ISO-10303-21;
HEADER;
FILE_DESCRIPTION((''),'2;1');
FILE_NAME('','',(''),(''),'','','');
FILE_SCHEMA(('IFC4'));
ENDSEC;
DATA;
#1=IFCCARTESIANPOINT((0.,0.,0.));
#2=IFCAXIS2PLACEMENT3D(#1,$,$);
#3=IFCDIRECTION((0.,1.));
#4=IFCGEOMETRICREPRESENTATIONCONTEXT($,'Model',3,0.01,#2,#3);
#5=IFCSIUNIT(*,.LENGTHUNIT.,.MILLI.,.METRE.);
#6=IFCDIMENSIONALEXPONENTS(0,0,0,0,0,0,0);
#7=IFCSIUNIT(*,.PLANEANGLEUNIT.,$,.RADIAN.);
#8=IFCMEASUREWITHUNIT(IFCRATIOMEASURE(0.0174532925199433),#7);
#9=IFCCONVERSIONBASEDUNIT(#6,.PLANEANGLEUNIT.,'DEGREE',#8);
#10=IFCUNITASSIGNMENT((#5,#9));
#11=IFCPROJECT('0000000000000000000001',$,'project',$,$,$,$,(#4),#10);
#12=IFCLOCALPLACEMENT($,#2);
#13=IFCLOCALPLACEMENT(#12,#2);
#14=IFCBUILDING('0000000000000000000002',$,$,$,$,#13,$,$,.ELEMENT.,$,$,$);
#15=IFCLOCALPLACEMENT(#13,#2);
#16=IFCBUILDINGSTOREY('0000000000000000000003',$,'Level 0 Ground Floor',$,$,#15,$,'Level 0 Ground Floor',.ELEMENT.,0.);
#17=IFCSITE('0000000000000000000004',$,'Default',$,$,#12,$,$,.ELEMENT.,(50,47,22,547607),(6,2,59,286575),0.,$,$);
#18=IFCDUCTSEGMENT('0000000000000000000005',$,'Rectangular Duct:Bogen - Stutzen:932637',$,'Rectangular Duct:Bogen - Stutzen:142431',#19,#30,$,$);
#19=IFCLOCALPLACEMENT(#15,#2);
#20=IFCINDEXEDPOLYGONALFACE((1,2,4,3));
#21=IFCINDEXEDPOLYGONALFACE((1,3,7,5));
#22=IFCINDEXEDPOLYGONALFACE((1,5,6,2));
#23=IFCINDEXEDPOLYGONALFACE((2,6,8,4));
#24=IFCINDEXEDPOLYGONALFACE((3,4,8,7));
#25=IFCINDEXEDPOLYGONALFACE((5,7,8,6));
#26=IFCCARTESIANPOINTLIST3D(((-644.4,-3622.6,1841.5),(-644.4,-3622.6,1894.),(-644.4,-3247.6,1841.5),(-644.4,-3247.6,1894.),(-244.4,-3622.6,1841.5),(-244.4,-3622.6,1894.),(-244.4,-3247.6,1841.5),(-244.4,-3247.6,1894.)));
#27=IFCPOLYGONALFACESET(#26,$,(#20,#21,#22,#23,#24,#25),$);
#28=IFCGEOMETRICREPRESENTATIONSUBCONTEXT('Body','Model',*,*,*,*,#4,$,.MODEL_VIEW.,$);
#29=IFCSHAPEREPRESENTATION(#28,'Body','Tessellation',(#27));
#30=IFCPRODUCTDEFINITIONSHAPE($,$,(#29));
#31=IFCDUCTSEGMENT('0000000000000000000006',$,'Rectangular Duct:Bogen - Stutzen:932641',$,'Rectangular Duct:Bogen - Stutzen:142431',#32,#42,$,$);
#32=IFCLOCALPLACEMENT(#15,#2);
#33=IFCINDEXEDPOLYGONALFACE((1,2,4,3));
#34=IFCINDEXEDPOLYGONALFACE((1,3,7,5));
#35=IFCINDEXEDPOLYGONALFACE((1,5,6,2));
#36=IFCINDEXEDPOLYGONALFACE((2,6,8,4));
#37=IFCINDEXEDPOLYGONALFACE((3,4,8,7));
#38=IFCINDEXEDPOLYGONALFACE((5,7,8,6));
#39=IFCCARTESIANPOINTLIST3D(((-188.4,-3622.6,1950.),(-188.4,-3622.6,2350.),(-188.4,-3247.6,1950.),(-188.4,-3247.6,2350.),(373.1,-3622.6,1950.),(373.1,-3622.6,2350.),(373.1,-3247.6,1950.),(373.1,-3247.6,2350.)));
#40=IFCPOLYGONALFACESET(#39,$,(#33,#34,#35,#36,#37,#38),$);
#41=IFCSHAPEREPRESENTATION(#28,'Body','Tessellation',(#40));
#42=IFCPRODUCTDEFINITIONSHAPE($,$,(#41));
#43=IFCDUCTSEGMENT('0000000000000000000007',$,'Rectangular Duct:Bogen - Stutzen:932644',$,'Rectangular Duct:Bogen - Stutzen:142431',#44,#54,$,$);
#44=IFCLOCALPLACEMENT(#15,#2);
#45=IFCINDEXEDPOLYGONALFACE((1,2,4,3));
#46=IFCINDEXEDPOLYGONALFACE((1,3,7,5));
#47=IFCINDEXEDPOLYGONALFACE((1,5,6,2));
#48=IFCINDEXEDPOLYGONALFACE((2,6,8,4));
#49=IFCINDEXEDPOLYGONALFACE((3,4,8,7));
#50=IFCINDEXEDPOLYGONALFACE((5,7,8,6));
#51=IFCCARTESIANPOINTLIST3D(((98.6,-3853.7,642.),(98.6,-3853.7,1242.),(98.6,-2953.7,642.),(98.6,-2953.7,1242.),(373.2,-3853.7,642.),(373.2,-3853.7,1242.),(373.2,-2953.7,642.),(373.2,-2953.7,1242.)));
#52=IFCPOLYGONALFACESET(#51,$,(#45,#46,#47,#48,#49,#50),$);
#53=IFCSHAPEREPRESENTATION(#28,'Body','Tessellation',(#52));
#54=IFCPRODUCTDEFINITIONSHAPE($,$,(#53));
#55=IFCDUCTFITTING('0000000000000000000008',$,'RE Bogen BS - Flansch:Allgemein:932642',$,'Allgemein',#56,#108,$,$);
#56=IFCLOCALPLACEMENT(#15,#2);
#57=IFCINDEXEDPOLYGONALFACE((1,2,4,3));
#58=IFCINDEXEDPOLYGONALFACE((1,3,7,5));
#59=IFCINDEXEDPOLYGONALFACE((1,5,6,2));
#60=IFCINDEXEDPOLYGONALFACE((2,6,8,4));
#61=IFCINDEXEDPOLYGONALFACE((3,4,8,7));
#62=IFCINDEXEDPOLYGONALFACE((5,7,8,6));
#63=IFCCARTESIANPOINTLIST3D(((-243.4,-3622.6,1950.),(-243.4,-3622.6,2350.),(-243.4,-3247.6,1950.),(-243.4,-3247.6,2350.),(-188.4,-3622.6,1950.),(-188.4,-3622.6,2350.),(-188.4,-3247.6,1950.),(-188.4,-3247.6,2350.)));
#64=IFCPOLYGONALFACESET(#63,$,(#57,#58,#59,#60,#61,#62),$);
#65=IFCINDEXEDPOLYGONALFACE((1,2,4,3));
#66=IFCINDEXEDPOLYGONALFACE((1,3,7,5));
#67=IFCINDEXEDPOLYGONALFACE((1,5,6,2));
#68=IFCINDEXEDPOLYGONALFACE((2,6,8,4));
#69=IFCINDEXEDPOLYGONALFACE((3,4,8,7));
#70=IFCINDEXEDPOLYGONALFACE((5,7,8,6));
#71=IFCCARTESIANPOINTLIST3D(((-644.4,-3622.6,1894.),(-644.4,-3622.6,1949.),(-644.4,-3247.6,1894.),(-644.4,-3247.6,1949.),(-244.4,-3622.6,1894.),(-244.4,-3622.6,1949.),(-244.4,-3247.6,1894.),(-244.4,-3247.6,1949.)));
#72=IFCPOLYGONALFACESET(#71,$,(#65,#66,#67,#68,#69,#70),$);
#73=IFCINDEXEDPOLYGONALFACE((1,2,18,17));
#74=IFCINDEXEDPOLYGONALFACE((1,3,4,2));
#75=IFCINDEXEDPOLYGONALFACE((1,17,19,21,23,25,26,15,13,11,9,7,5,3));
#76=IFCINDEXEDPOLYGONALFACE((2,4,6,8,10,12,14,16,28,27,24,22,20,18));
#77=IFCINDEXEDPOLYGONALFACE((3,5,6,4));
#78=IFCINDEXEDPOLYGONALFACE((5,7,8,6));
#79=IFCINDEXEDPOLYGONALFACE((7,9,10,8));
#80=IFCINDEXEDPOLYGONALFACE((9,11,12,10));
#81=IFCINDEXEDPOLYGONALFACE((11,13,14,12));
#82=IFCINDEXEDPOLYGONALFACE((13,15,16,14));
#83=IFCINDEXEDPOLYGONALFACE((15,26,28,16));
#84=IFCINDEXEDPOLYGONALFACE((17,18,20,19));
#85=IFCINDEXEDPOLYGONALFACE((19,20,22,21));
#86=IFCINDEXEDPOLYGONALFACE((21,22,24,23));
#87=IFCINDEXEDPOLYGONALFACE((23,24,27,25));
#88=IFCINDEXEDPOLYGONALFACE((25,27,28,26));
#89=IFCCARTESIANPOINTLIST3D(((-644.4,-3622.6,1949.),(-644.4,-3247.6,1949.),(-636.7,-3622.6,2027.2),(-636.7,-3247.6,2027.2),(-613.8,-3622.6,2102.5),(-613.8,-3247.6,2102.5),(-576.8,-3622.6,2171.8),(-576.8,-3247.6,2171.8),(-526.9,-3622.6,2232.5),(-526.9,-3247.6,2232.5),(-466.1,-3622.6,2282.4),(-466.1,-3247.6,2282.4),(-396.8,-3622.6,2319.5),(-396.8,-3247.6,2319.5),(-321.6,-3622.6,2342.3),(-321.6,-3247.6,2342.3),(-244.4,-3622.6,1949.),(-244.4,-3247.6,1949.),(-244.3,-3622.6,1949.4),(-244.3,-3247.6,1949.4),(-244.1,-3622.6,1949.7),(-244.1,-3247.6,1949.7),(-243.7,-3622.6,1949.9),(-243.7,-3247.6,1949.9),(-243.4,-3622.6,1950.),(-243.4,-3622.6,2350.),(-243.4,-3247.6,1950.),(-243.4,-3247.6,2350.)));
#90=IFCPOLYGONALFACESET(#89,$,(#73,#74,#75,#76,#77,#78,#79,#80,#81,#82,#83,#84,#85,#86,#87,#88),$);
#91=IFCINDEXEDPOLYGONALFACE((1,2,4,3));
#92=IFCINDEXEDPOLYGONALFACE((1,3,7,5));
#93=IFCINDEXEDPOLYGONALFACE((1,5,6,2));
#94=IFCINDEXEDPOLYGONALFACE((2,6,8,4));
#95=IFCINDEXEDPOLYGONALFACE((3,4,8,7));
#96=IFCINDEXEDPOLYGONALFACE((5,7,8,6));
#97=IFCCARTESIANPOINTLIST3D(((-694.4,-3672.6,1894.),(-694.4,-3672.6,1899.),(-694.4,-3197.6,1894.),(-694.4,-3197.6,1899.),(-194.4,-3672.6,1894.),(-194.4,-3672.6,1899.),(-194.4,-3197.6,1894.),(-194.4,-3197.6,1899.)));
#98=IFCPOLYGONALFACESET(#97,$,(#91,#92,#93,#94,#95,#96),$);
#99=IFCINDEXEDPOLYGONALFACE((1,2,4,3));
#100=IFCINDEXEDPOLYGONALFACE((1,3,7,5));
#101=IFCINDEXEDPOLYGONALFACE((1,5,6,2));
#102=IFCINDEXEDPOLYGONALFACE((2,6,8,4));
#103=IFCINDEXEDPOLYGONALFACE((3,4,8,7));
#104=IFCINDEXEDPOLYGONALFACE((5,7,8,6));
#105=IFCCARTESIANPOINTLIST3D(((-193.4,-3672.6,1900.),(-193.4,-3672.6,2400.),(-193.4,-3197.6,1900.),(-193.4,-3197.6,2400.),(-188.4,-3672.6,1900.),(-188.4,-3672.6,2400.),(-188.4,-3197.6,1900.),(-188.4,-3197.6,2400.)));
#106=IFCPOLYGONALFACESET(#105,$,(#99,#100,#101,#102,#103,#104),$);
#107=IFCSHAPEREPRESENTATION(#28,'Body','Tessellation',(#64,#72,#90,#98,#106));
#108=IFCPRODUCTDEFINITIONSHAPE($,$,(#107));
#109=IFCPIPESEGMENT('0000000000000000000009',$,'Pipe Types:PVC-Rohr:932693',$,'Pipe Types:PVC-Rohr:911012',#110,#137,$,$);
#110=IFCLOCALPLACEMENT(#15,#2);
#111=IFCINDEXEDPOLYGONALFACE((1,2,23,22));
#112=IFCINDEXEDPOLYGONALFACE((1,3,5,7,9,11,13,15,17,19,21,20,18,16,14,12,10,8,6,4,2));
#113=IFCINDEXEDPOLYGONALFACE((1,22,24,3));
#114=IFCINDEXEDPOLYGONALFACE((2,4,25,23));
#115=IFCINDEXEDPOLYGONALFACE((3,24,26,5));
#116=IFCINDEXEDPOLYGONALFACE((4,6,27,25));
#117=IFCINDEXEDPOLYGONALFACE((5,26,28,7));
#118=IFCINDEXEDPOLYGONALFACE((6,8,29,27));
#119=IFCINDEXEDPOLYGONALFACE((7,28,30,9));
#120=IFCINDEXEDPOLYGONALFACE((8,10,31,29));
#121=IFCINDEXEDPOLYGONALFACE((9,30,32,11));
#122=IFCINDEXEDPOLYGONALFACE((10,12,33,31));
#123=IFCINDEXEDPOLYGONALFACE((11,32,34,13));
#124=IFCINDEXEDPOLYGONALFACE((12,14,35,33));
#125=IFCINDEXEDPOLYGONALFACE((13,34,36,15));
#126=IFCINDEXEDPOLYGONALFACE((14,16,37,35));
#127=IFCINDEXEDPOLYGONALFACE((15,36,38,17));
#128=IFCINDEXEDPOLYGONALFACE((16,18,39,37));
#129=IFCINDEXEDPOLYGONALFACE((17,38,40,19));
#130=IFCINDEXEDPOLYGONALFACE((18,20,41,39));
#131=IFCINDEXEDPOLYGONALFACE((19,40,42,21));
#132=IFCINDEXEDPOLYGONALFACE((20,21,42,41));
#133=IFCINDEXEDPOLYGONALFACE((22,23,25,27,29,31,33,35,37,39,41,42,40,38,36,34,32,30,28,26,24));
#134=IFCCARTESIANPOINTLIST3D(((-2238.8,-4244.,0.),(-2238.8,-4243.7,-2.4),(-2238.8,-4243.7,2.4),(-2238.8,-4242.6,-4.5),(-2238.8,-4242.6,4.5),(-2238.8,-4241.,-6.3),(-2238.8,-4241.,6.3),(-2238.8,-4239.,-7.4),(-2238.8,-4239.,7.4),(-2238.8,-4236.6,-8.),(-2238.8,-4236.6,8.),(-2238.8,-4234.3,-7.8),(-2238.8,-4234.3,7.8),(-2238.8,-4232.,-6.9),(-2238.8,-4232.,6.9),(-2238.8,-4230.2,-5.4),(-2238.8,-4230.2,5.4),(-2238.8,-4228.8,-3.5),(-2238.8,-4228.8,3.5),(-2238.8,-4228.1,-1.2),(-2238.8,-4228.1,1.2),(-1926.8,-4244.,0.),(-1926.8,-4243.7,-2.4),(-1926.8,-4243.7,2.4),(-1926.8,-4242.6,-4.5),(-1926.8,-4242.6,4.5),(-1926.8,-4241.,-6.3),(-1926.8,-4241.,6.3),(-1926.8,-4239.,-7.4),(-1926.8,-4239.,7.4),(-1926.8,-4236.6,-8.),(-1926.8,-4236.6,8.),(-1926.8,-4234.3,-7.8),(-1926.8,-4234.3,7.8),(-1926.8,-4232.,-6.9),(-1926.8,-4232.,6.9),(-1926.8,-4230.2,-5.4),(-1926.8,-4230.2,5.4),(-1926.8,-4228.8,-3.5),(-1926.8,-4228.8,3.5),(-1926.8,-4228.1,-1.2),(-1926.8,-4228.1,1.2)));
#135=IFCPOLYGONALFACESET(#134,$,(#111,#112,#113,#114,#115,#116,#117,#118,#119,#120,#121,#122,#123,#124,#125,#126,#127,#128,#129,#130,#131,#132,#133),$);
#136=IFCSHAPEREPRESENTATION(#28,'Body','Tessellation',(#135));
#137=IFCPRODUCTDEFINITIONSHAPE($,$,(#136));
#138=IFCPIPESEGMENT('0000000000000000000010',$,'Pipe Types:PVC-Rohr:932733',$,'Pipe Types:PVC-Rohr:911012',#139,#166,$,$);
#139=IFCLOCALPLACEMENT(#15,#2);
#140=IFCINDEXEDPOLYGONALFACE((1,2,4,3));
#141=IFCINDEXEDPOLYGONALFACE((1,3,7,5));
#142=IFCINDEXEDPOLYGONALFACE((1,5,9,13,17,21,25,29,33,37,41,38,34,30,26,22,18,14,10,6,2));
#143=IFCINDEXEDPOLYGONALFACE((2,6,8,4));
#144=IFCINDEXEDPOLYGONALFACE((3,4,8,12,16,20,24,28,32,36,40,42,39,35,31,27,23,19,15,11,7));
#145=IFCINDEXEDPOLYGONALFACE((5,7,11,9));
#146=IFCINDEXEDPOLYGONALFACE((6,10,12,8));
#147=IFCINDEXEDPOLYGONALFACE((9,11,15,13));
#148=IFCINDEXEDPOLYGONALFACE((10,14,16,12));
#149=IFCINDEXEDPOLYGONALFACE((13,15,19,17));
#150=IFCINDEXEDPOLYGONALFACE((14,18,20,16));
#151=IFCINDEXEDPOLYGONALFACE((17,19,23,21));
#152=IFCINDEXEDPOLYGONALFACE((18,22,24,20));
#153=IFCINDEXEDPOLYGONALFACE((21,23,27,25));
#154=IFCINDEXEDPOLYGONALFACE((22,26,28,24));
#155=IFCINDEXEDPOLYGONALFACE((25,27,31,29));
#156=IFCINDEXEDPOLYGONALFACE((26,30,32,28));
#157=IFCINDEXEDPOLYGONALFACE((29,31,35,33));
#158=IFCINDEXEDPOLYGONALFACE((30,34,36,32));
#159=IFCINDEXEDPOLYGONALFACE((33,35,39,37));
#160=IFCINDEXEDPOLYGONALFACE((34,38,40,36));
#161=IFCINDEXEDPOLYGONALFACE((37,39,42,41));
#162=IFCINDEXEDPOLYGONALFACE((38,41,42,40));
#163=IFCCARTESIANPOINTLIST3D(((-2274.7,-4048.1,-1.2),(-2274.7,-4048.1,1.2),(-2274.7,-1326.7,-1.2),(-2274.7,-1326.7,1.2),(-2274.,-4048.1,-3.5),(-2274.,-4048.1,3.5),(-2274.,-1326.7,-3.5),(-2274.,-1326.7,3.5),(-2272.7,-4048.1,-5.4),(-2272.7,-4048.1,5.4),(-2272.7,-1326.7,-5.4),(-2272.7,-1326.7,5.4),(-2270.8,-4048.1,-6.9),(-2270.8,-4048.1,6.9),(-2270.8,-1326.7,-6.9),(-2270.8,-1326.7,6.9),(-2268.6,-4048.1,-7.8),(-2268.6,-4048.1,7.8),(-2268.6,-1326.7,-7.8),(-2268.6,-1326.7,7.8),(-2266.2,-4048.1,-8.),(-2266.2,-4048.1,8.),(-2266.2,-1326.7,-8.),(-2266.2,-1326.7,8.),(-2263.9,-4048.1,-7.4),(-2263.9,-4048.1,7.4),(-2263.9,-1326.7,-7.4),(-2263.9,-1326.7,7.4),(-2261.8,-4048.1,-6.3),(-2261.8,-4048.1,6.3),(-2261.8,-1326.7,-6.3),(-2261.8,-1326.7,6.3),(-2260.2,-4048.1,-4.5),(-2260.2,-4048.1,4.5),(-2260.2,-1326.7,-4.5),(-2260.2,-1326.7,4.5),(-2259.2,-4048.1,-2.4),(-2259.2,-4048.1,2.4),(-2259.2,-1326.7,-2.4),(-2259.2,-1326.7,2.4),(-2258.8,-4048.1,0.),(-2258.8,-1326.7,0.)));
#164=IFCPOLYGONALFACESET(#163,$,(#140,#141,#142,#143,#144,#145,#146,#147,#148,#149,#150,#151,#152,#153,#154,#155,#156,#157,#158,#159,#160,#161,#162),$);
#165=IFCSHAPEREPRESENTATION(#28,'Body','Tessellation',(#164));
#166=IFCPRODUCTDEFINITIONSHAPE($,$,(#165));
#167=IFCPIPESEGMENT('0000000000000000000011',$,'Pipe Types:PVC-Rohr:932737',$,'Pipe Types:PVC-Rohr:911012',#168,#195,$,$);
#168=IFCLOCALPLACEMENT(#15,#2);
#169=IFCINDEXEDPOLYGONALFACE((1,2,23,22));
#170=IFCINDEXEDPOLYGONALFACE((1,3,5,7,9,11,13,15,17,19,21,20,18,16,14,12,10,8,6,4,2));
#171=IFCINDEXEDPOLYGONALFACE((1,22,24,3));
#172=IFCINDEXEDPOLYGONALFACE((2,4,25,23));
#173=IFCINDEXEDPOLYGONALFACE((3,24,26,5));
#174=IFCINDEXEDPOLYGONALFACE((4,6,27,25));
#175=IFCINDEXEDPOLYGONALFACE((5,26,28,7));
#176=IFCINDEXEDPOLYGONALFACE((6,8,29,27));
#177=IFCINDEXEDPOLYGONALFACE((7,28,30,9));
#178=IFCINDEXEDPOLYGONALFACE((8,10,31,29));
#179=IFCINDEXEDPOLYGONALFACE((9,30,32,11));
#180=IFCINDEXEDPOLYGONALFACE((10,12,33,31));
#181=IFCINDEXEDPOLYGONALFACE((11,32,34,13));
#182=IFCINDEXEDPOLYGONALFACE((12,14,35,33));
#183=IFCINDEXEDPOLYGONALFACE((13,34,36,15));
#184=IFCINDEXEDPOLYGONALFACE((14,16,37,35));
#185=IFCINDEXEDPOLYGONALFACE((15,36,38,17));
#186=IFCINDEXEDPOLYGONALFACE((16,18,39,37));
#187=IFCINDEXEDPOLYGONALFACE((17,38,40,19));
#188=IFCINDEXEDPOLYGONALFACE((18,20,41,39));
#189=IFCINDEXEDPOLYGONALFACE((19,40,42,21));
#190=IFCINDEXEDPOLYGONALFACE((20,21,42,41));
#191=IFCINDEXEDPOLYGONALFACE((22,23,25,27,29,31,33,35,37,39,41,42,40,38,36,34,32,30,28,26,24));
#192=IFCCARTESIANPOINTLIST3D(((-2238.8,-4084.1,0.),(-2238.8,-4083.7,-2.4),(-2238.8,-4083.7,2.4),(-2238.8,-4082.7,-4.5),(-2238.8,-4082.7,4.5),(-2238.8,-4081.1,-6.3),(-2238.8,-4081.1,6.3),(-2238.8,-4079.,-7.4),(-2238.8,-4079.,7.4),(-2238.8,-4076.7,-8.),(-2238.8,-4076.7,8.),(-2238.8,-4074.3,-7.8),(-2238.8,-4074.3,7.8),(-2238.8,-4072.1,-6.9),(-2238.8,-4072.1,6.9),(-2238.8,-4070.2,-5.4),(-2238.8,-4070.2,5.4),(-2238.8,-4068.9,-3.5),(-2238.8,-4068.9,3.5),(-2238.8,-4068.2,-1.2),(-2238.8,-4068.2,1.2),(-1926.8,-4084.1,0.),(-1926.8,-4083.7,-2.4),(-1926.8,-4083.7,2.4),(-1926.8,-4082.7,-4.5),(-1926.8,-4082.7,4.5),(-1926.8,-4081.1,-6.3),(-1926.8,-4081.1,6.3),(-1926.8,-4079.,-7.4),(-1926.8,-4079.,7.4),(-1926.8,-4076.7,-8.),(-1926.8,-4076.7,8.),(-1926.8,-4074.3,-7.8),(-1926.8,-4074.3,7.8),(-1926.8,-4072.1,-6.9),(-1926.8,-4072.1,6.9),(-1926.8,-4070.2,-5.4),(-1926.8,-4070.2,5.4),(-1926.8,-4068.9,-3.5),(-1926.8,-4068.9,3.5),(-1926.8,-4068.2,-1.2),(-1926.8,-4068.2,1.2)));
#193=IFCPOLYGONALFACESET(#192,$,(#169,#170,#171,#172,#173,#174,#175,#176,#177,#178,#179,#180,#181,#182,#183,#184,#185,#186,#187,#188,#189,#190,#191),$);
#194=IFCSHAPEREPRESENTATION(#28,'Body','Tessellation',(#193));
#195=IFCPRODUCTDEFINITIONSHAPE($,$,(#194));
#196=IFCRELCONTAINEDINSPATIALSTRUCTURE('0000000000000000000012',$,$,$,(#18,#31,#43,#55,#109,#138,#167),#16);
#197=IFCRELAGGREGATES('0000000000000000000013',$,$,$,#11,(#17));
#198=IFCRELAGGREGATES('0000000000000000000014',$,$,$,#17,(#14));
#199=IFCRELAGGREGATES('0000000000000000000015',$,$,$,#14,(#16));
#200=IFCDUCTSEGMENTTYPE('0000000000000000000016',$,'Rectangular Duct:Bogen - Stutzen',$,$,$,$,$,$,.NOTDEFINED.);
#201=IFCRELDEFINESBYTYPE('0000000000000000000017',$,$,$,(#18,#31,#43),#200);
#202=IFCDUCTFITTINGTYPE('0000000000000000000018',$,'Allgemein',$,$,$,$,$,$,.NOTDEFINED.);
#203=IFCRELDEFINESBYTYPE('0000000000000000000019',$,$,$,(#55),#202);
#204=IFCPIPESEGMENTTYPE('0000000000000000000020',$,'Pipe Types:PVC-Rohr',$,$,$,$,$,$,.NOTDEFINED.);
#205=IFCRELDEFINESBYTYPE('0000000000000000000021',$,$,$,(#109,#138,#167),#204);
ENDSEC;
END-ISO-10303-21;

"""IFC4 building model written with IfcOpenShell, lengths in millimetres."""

from ifc_helpers import new_model, entity, si_unit, converted_unit, direction, frame, frame_2d, origin, origin_2d_with_axis, place, context, subcontext, project, spatial, polyline, circle_curve, parameter, trimmed, segment, composite_curve, rectangle, circle, outline, extrude, source, transform, mapped, type_object, type_shapes, element, save


model = new_model("IFC4")

# Units and contexts
model_context = context("Model", 3, precision=0.01, world=origin(), true_north=direction((0.0, 1.0)))
body_context = subcontext(model_context, "Body", "Model", "MODEL_VIEW")
ifc_project = project(units=[si_unit("LENGTHUNIT", "METRE", prefix="MILLI"), converted_unit("PLANEANGLEUNIT", "DEGREE", entity("IfcRatioMeasure", 0.0174532925199433), si_unit("PLANEANGLEUNIT", "RADIAN"), dimensions=[0, 0, 0, 0, 0, 0, 0])], contexts=[model_context])

# Site, building, storey
site_placement = place(None, origin())
site = spatial("IfcSite", under=ifc_project, at=site_placement, Name="Default", CompositionType="ELEMENT", RefLatitude=(50, 47, 22, 547607), RefLongitude=(6, 2, 59, 286575), RefElevation=0.0)
building_placement = place(site_placement, origin())
building = spatial("IfcBuilding", under=site, at=building_placement, CompositionType="ELEMENT")
storey_placement = place(building_placement, origin())
storey = spatial("IfcBuildingStorey", under=building, at=storey_placement, Name="Level 0 Ground Floor", LongName="Level 0 Ground Floor", CompositionType="ELEMENT", Elevation=0.0)

# Duct segments
duct_segment_type = type_object("IfcDuctSegmentType", Name="Rectangular Duct:Bogen - Stutzen", PredefinedType="NOTDEFINED")
duct_segment_1_placement = place(storey_placement, frame((-644.4, -3622.6, 1841.5)))
element("IfcDuctSegment", 1, at=duct_segment_1_placement, inside=storey, type_object=duct_segment_type, Name="Rectangular Duct:Bogen - Stutzen:932637", ObjectType="Rectangular Duct:Bogen - Stutzen:142431", context=body_context, shape_type="SweptSolid", body=[
    extrude(rectangle(XDim=375.0, YDim=400.0, at=origin_2d_with_axis()), frame((200.0, 187.5, 0.0), z_axis=(0.0, 0.0, 1.0), x_axis=(0.0, 1.0, 0.0)), (0.0, 0.0, 1.0), 52.5),
])
duct_segment_2_placement = place(storey_placement, frame((-188.4, -3622.6, 1950.0)))
element("IfcDuctSegment", 2, at=duct_segment_2_placement, inside=storey, type_object=duct_segment_type, Name="Rectangular Duct:Bogen - Stutzen:932641", ObjectType="Rectangular Duct:Bogen - Stutzen:142431", context=body_context, shape_type="SweptSolid", body=[
    extrude(rectangle(XDim=561.5, YDim=375.0, at=origin_2d_with_axis()), frame((280.8, 187.5, 0.0)), (0.0, 0.0, 1.0), 400.0),
])
duct_segment_3_placement = place(storey_placement, frame((98.6, -3853.7, 642.0)))
element("IfcDuctSegment", 3, at=duct_segment_3_placement, inside=storey, type_object=duct_segment_type, Name="Rectangular Duct:Bogen - Stutzen:932644", ObjectType="Rectangular Duct:Bogen - Stutzen:142431", context=body_context, shape_type="SweptSolid", body=[
    extrude(rectangle(XDim=274.6, YDim=900.0, at=frame_2d((0.0, 0.0), x_axis=(1.0, 0.0))), frame((137.3, 450.0, 0.0)), (0.0, 0.0, 1.0), 600.0),
])

# Duct fitting
duct_fitting_type = type_object("IfcDuctFittingType", Name="Allgemein", PredefinedType="NOTDEFINED")
shared_shape_1 = source(origin(), body_context, "Body", "SweptSolid", [
    extrude(rectangle(XDim=55.0, YDim=400.0, at=frame_2d((0.0, 0.0), x_axis=(1.0, 0.0))), frame((0.0, 228.5, -187.5), z_axis=(0.0, 0.0, 1.0), x_axis=(0.0, 1.0, 0.0)), (0.0, 0.0, 1.0), 375.0),
    extrude(rectangle(XDim=400.0, YDim=55.0, at=frame_2d((0.0, 0.0), x_axis=(1.0, 0.0))), frame((-228.5, 0.0, -187.5), z_axis=(0.0, 0.0, 1.0), x_axis=(0.0, -1.0, 0.0)), (0.0, 0.0, 1.0), 375.0),
    extrude(outline(composite_curve([segment(polyline([(-300.5, -100.5), (99.5, -100.5)]), True, "CONTINUOUS"), segment(trimmed(circle_curve(frame_2d((100.5, -100.5), x_axis=(0.0, 1.0)), 1.0), [parameter(0.0)], [parameter(90.0)], True, "PARAMETER"), False, "CONTINUOUS"), segment(polyline([(100.5, -99.5), (100.5, 300.5)]), True, "CONTINUOUS"), segment(trimmed(circle_curve(frame_2d((100.5, -100.5), x_axis=(0.0, 1.0)), 401.0), [parameter(0.0)], [parameter(90.0)], True, "PARAMETER"), True, "CONTINUOUS")], self_intersect=False)), frame((-100.5, 100.5, -187.5), z_axis=(0.0, 0.0, 1.0), x_axis=(-1.0, 0.0, 0.0)), (0.0, 0.0, 1.0), 375.0),
    extrude(rectangle(XDim=5.0, YDim=500.0, at=frame_2d((0.0, 0.0), x_axis=(1.0, 0.0))), frame((-253.5, 0.0, -237.5)), (0.0, 0.0, 1.0), 475.0),
    extrude(rectangle(XDim=5.0, YDim=500.0, at=origin_2d_with_axis()), frame((0.0, 253.5, -237.5), z_axis=(0.0, 0.0, 1.0), x_axis=(0.0, 1.0, 0.0)), (0.0, 0.0, 1.0), 475.0),
])
type_shapes(duct_fitting_type, [shared_shape_1])
duct_fitting_placement = place(storey_placement, frame((-444.4, -3435.1, 2150.0), z_axis=(0.0, 1.0, 0.0), x_axis=(0.0, 0.0, 1.0)))
element("IfcDuctFitting", 4, at=duct_fitting_placement, inside=storey, type_object=duct_fitting_type, Name="RE Bogen BS - Flansch:Allgemein:932642", ObjectType="Allgemein", context=body_context, shape_type="MappedRepresentation", body=[
    mapped(shared_shape_1, transform((0.0, 0.0, 0.0), scale=1.0)),
])

# Pipe segments
pipe_segment_type_1 = type_object("IfcPipeSegmentType", Name="Pipe Types:PVC-Rohr", PredefinedType="NOTDEFINED")
pipe_segment_1_placement = place(storey_placement, frame((-2238.8, -4245.6, -9.6)))
element("IfcPipeSegment", 5, at=pipe_segment_1_placement, inside=storey, type_object=pipe_segment_type_1, Name="Pipe Types:PVC-Rohr:932693", ObjectType="Pipe Types:PVC-Rohr:911012", context=body_context, shape_type="SweptSolid", body=[
    extrude(circle(Radius=8.0, at=frame_2d((0.0, 0.0), x_axis=(1.0, 0.0))), frame((0.0, 9.6, 9.6), z_axis=(1.0, 0.0, 0.0), x_axis=(0.0, -1.0, 0.0)), (0.0, 0.0, 1.0), 312.0),
])
pipe_segment_2_placement = place(storey_placement, frame((-2276.4, -4048.1, -9.6)))
element("IfcPipeSegment", 6, at=pipe_segment_2_placement, inside=storey, type_object=pipe_segment_type_1, Name="Pipe Types:PVC-Rohr:932733", ObjectType="Pipe Types:PVC-Rohr:911012", context=body_context, shape_type="SweptSolid", body=[
    extrude(circle(Radius=8.0, at=frame_2d((0.0, 0.0), x_axis=(1.0, 0.0))), frame((9.6, 0.0, 9.6), z_axis=(0.0, 1.0, 0.0), x_axis=(1.0, 0.0, 0.0)), (0.0, 0.0, 1.0), 2721.3),
])
pipe_segment_3_placement = place(storey_placement, frame((-2238.8, -4085.7, -9.6)))
element("IfcPipeSegment", 7, at=pipe_segment_3_placement, inside=storey, type_object=pipe_segment_type_1, Name="Pipe Types:PVC-Rohr:932737", ObjectType="Pipe Types:PVC-Rohr:911012", context=body_context, shape_type="SweptSolid", body=[
    extrude(circle(Radius=8.0, at=frame_2d((0.0, 0.0), x_axis=(1.0, 0.0))), frame((0.0, 9.6, 9.6), z_axis=(1.0, 0.0, 0.0), x_axis=(0.0, -1.0, 0.0)), (0.0, 0.0, 1.0), 312.0),
])

save(model, "model.ifc")
